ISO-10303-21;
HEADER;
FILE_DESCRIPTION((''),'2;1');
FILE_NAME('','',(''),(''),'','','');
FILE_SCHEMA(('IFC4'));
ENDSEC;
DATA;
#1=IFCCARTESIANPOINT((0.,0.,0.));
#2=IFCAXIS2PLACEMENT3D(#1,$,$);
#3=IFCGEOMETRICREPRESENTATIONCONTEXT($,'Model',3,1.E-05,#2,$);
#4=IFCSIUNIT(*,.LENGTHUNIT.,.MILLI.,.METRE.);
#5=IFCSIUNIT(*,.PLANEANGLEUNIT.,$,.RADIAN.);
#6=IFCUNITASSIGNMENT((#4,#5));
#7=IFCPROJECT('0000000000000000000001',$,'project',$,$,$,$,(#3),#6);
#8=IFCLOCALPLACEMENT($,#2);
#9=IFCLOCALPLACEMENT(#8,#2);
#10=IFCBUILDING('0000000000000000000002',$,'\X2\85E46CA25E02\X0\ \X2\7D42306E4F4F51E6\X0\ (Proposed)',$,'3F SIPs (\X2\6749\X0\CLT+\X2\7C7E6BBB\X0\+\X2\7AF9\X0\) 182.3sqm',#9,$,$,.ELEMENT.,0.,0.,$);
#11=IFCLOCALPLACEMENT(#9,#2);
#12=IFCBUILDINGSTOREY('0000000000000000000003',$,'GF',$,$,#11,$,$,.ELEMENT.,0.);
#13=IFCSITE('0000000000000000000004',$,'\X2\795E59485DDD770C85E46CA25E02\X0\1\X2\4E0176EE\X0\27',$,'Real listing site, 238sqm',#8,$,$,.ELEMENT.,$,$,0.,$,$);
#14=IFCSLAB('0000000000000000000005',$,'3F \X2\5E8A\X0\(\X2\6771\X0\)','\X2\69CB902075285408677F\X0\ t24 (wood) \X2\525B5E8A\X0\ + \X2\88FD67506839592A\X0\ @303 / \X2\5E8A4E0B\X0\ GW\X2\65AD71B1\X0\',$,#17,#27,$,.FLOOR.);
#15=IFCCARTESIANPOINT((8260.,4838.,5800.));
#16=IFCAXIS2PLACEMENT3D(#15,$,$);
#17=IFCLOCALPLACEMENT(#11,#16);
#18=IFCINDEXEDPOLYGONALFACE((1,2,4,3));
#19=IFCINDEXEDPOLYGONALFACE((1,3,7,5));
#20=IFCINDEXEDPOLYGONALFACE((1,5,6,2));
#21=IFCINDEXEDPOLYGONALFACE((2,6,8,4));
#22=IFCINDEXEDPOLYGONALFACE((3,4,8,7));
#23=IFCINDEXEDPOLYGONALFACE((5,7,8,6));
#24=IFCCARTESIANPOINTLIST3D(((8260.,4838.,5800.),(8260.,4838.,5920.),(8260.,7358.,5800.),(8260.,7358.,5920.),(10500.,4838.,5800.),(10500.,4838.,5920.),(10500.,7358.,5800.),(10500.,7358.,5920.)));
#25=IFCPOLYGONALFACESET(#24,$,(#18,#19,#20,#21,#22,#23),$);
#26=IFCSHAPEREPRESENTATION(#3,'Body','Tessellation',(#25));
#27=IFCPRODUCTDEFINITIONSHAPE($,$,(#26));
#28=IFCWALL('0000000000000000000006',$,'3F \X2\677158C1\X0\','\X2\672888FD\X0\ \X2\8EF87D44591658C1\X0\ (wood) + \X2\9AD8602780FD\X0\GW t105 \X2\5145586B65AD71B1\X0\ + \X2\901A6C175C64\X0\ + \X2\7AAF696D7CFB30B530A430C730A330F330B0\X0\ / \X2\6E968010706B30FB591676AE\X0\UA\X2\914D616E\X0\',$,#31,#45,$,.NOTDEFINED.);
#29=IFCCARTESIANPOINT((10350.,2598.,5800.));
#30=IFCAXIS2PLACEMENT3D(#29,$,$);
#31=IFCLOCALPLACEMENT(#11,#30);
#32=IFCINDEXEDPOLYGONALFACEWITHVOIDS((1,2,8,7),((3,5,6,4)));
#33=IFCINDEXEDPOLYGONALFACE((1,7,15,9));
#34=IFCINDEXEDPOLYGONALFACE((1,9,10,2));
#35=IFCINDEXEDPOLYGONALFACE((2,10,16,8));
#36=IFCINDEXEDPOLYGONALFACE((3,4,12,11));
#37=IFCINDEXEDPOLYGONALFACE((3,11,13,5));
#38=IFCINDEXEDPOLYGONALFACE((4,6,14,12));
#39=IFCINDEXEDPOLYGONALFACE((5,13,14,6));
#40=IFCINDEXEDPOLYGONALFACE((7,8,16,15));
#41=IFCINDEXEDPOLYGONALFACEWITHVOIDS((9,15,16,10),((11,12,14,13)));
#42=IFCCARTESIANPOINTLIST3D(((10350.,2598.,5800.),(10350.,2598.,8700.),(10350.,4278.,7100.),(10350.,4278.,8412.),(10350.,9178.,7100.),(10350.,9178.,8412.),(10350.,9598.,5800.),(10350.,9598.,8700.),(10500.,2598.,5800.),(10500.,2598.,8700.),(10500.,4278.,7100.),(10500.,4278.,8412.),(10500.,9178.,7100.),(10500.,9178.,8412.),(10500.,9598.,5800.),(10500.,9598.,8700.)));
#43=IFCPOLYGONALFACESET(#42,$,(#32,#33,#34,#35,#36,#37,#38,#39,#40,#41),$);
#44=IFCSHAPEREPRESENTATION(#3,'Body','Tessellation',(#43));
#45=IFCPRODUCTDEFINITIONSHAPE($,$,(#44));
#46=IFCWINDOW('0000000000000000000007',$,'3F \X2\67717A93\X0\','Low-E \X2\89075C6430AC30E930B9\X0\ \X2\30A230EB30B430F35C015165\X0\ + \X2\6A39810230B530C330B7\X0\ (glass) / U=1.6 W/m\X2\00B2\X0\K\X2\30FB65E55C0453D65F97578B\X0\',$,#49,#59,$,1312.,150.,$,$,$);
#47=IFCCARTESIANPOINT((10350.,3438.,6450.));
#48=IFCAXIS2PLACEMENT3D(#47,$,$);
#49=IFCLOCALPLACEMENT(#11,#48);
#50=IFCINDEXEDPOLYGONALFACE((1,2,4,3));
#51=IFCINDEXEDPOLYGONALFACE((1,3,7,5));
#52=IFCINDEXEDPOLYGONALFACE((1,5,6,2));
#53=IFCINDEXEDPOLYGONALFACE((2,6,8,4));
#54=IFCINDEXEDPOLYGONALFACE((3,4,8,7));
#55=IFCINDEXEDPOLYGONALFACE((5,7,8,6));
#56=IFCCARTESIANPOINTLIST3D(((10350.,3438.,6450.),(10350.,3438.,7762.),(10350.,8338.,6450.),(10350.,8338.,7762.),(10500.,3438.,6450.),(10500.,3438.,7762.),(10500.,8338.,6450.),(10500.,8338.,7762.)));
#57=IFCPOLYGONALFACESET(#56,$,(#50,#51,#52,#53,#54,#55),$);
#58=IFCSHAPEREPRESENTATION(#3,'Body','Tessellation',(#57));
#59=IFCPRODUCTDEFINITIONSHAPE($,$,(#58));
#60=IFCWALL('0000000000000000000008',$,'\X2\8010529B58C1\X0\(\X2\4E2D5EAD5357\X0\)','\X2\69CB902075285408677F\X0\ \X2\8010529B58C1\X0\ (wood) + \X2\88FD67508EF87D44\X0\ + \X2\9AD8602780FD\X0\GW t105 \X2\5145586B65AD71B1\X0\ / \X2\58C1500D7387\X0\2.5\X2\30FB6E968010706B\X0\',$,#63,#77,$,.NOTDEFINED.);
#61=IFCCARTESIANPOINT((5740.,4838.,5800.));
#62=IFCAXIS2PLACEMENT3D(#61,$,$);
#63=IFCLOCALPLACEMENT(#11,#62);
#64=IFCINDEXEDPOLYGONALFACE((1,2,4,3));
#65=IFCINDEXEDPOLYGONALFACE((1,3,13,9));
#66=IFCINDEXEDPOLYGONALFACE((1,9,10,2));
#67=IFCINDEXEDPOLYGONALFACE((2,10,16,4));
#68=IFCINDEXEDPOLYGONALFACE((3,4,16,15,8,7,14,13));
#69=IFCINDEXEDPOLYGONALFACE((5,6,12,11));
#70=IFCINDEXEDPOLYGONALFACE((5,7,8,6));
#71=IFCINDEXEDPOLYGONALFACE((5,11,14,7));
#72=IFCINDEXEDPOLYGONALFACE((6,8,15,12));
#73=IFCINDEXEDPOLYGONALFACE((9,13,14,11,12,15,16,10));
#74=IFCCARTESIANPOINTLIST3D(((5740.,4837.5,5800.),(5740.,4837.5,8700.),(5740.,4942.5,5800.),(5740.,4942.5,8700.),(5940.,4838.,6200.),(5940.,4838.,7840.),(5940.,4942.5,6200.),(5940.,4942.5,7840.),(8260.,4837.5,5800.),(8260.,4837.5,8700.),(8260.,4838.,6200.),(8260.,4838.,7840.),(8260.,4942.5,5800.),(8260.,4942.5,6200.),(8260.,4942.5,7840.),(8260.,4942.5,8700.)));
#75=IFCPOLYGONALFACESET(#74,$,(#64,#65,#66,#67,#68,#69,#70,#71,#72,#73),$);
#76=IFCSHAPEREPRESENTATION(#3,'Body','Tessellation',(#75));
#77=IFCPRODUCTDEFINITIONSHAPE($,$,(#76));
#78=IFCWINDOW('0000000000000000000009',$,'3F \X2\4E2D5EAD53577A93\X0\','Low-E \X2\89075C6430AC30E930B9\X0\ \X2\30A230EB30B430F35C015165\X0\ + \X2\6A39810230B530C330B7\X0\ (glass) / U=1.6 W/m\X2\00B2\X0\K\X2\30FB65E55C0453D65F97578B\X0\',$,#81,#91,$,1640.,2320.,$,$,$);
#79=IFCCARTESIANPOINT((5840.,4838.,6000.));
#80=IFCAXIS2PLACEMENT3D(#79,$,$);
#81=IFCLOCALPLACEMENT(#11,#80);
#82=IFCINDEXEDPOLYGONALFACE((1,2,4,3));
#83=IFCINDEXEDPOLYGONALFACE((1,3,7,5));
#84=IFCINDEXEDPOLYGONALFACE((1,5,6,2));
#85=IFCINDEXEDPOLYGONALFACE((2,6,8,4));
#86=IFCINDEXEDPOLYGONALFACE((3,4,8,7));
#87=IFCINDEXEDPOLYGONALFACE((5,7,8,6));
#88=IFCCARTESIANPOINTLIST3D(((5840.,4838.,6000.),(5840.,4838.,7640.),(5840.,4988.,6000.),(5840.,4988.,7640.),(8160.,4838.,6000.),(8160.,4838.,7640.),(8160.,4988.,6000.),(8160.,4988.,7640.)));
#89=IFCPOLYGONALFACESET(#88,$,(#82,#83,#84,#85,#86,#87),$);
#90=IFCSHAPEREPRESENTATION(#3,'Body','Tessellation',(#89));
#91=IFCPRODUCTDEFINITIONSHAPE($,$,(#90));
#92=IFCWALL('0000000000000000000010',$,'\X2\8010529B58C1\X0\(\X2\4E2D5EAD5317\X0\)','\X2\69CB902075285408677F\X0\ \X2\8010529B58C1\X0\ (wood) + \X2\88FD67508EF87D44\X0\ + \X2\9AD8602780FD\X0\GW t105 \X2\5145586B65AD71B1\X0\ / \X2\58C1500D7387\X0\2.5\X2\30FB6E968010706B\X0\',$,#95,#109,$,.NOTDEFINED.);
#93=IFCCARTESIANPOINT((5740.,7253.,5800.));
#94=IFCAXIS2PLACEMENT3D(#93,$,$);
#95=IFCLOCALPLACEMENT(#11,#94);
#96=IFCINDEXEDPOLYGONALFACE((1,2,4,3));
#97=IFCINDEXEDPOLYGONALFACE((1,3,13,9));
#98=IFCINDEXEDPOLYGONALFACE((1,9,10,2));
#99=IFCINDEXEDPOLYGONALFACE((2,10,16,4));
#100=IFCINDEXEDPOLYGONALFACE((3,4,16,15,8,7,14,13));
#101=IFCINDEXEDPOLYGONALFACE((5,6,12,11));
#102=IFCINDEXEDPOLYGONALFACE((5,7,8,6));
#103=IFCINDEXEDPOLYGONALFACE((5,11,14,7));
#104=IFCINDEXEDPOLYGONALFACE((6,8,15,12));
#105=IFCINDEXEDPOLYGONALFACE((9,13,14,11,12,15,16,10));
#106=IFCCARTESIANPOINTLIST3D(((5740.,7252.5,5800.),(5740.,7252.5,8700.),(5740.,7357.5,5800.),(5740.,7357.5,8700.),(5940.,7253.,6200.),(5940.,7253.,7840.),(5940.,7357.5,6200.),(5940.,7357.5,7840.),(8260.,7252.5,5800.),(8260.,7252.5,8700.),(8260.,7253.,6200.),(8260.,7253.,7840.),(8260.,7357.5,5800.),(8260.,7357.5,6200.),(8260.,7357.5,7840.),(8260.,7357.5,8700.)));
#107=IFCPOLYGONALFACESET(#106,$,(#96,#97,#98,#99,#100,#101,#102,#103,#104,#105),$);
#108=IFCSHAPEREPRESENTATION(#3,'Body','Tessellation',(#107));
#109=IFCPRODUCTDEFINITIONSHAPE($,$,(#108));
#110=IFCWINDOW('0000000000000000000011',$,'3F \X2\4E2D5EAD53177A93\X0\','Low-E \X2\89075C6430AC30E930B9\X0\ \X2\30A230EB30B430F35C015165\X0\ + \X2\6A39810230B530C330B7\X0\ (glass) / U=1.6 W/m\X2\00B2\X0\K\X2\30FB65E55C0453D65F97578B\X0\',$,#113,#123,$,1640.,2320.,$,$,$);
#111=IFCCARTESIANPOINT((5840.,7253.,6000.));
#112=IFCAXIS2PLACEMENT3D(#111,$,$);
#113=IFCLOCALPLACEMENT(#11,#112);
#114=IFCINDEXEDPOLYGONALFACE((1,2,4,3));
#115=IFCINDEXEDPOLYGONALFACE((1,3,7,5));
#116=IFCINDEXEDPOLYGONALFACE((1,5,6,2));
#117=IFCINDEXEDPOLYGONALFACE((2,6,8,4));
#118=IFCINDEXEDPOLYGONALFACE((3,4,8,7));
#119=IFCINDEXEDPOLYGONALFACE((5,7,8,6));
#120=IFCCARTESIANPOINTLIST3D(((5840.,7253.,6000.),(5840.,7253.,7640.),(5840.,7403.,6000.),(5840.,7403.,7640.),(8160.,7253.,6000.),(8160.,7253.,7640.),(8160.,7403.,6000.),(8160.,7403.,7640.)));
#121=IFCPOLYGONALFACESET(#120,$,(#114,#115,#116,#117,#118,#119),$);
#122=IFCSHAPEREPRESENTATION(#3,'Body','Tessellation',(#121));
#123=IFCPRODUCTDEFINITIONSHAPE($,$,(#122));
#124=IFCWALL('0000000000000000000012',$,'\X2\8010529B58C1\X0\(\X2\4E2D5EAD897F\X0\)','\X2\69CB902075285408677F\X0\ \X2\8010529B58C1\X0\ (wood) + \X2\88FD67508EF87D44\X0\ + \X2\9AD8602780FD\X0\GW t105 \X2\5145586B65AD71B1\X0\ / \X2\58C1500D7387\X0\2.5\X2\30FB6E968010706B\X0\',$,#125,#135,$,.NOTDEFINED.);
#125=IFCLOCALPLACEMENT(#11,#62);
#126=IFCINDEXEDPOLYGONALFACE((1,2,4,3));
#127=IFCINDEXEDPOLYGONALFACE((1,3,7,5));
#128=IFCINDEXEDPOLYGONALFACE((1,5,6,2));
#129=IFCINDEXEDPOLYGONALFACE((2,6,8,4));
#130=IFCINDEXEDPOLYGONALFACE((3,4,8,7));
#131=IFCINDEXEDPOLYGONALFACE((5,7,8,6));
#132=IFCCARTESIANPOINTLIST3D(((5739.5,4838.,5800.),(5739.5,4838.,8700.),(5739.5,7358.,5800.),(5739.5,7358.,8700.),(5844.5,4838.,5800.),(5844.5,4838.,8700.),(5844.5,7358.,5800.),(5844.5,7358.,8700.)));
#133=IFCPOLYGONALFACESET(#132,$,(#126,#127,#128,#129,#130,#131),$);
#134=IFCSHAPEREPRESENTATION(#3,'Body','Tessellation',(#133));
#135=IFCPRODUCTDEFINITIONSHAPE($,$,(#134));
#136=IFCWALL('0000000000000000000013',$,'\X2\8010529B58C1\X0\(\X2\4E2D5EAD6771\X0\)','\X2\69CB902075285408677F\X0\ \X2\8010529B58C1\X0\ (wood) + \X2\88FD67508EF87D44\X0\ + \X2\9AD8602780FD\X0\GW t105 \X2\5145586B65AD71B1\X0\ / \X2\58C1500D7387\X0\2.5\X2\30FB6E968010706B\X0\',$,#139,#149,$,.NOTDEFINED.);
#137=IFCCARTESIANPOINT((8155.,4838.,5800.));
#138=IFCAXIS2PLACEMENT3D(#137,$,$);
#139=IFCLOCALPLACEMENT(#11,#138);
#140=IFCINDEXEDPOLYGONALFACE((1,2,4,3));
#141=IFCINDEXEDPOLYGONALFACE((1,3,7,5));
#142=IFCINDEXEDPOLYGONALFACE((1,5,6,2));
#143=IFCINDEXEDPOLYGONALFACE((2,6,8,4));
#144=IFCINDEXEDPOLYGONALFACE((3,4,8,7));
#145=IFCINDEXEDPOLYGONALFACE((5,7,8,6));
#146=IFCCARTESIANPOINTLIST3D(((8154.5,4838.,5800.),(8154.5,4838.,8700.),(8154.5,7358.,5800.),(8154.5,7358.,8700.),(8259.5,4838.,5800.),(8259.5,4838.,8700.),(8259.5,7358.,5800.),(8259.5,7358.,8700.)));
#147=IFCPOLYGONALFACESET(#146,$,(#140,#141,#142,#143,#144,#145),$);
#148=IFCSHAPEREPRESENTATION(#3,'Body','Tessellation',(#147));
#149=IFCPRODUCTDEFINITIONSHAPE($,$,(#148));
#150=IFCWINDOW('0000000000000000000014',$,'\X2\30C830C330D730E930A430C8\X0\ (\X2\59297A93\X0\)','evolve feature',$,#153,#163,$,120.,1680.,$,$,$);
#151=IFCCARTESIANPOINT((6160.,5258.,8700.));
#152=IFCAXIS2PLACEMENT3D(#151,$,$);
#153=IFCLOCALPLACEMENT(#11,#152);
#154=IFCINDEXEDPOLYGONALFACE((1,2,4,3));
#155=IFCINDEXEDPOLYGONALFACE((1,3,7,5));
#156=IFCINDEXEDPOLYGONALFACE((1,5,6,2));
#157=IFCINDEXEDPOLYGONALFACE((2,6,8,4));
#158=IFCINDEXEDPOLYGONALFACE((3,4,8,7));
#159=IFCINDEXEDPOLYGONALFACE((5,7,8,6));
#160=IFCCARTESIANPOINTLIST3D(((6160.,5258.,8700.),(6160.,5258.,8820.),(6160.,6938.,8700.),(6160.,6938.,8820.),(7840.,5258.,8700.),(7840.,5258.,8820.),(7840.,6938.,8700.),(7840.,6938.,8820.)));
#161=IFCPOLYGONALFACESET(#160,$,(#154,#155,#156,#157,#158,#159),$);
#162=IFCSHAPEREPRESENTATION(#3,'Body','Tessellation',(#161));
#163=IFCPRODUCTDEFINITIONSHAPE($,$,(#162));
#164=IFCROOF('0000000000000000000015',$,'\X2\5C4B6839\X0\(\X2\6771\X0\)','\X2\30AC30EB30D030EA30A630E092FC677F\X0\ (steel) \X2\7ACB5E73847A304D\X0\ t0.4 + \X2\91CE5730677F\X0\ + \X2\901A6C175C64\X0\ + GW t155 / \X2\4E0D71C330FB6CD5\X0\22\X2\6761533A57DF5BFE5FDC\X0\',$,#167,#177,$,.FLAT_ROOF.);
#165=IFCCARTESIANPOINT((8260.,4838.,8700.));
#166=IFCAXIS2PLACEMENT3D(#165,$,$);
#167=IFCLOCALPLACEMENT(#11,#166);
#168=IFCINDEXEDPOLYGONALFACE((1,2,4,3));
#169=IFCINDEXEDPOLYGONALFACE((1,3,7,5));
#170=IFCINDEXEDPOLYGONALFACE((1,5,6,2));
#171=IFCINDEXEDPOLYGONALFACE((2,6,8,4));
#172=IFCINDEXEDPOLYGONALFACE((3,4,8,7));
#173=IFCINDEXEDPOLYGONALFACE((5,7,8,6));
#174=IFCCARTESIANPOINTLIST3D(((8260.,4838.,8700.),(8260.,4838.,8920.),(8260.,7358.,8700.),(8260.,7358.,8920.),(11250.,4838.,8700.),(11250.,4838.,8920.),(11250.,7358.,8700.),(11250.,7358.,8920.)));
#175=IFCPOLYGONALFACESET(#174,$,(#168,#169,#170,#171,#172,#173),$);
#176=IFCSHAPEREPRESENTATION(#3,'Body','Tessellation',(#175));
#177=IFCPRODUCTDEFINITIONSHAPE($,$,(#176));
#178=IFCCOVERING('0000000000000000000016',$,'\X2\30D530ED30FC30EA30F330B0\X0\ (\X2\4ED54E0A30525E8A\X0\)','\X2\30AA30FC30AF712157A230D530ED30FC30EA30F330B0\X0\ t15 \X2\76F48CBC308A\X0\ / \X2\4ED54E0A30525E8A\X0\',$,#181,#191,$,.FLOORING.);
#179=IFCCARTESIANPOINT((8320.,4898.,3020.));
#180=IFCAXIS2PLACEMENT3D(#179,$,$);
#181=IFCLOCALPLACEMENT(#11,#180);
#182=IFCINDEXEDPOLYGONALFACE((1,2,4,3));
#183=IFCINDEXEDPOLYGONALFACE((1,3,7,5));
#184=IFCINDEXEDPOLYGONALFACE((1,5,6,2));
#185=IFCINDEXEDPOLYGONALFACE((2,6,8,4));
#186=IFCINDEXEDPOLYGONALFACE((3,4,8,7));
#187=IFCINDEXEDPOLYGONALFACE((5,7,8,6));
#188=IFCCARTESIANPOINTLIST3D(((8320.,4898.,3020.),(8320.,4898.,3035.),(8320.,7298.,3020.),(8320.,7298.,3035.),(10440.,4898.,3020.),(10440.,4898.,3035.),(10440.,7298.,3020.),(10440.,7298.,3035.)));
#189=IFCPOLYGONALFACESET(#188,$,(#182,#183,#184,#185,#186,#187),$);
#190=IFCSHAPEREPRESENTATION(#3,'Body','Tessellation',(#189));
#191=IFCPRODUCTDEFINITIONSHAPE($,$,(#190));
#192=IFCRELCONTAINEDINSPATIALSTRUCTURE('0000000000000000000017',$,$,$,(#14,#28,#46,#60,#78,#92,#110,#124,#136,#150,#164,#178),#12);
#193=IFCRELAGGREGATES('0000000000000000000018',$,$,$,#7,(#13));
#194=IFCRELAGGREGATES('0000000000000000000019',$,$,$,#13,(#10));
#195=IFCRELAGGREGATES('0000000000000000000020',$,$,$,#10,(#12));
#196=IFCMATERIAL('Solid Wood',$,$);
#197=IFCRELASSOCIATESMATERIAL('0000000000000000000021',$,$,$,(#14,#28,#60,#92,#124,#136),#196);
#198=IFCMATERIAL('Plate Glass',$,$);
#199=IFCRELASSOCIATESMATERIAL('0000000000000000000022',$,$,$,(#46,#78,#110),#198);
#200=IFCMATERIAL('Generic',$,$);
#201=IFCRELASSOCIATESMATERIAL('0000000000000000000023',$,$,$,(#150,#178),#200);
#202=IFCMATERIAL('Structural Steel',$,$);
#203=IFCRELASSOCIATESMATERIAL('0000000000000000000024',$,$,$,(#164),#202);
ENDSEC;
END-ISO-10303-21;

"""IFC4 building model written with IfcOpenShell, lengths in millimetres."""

from ifc_helpers import new_model, si_unit, frame, frame_2d, origin, place, context, project, spatial, rectangle, extrude, material, element, fill, save


model = new_model("IFC4")

# Units and contexts
model_context = context("Model", 3, precision=1e-05, world=origin())
ifc_project = project(units=[si_unit("LENGTHUNIT", "METRE", prefix="MILLI"), si_unit("PLANEANGLEUNIT", "RADIAN")], contexts=[model_context])

# Site, building, storey
site_placement = place(None, origin())
site = spatial("IfcSite", under=ifc_project, at=site_placement, Name="神奈川県藤沢市1丁目27", ObjectType="Real listing site, 238sqm", CompositionType="ELEMENT", RefElevation=0.0)
building_placement = place(site_placement, origin())
building = spatial("IfcBuilding", under=site, at=building_placement, Name="藤沢市 終の住処 (Proposed)", ObjectType="3F SIPs (杉CLT+籾殻+竹) 182.3sqm", CompositionType="ELEMENT", ElevationOfRefHeight=0.0, ElevationOfTerrain=0.0)
storey_placement = place(building_placement, origin())
storey = spatial("IfcBuildingStorey", under=building, at=storey_placement, Name="GF", CompositionType="ELEMENT", Elevation=0.0)

# Slab
ifc_material_1 = material(Name="Solid Wood")
slab_placement = place(storey_placement, frame((8260.0, 4838.0, 5800.0)))
element("IfcSlab", 1, at=slab_placement, inside=storey, material=ifc_material_1, Name="3F 床(東)", Description="構造用合板 t24 (wood) 剛床 + 製材根太 @303 / 床下 GW断熱", PredefinedType="FLOOR", context=model_context, shape_type="SweptSolid", body=[
    extrude(rectangle(XDim=2240.0, YDim=2520.0, at=frame_2d((1120.0, 1260.0))), frame((8260.0, 4838.0, 5800.0)), (0.0, 0.0, 1.0), 120.0),
])

# Walls, openings, windows
wall_1_placement = place(storey_placement, frame((10350.0, 2598.0, 5800.0)))
wall_1 = element("IfcWall", 2, at=wall_1_placement, inside=storey, material=ifc_material_1, Name="3F 東壁", Description="木製 軸組外壁 (wood) + 高性能GW t105 充填断熱 + 通気層 + 窯業系サイディング / 準耐火・外皮UA配慮", PredefinedType="NOTDEFINED", context=model_context, shape_type="SweptSolid", body=[
    extrude(rectangle(XDim=150.0, YDim=7000.0, at=frame_2d((75.0, 3500.0))), frame((10350.0, 2598.0, 5800.0)), (0.0, 0.0, 1.0), 2900.0),
])
opening_1_placement = place(storey_placement, frame((10350.0, 3438.0, 6450.0)))
opening_1 = element("IfcOpeningElement", 3, at=opening_1_placement, cuts=wall_1, PredefinedType="NOTDEFINED", context=model_context, shape_type="SweptSolid", body=[
    extrude(rectangle(XDim=150.0, YDim=4900.0, at=frame_2d((75.0, 2450.0))), frame((10350.0, 3438.0, 6450.0)), (0.0, 0.0, 1.0), 1312.0),
])
ifc_material_2 = material(Name="Plate Glass")
window_1_placement = place(storey_placement, frame((10350.0, 3438.0, 6450.0)))
window_1 = element("IfcWindow", 4, at=window_1_placement, inside=storey, material=ifc_material_2, Name="3F 東窓", Description="Low-E 複層ガラス アルゴン封入 + 樹脂サッシ (glass) / U=1.6 W/m²K・日射取得型", OverallHeight=1312.0, OverallWidth=150.0, context=model_context, shape_type="SweptSolid", body=[
    extrude(rectangle(XDim=150.0, YDim=4900.0, at=frame_2d((75.0, 2450.0))), frame((10350.0, 3438.0, 6450.0)), (0.0, 0.0, 1.0), 1312.0),
])
fill(opening_1, window_1)
wall_2_placement = place(storey_placement, frame((5740.0, 4838.0, 5800.0)))
wall_2 = element("IfcWall", 5, at=wall_2_placement, inside=storey, material=ifc_material_1, Name="耐力壁(中庭南)", Description="構造用合板 耐力壁 (wood) + 製材軸組 + 高性能GW t105 充填断熱 / 壁倍率2.5・準耐火", PredefinedType="NOTDEFINED", context=model_context, shape_type="SweptSolid", body=[
    extrude(rectangle(XDim=2520.0, YDim=105.0, at=frame_2d((1260.0, 52.0))), frame((5740.0, 4838.0, 5800.0)), (0.0, 0.0, 1.0), 2900.0),
])
opening_2_placement = place(storey_placement, frame((5840.0, 4838.0, 6000.0)))
opening_2 = element("IfcOpeningElement", 6, at=opening_2_placement, cuts=wall_2, PredefinedType="NOTDEFINED", context=model_context, shape_type="SweptSolid", body=[
    extrude(rectangle(XDim=2320.0, YDim=150.0, at=frame_2d((1160.0, 75.0))), frame((5840.0, 4838.0, 6000.0)), (0.0, 0.0, 1.0), 1640.0),
])
window_2_placement = place(storey_placement, frame((5840.0, 4838.0, 6000.0)))
window_2 = element("IfcWindow", 7, at=window_2_placement, inside=storey, material=ifc_material_2, Name="3F 中庭南窓", Description="Low-E 複層ガラス アルゴン封入 + 樹脂サッシ (glass) / U=1.6 W/m²K・日射取得型", OverallHeight=1640.0, OverallWidth=2320.0, context=model_context, shape_type="SweptSolid", body=[
    extrude(rectangle(XDim=2320.0, YDim=150.0, at=frame_2d((1160.0, 75.0))), frame((5840.0, 4838.0, 6000.0)), (0.0, 0.0, 1.0), 1640.0),
])
fill(opening_2, window_2)
wall_3_placement = place(storey_placement, frame((5740.0, 7253.0, 5800.0)))
wall_3 = element("IfcWall", 8, at=wall_3_placement, inside=storey, material=ifc_material_1, Name="耐力壁(中庭北)", Description="構造用合板 耐力壁 (wood) + 製材軸組 + 高性能GW t105 充填断熱 / 壁倍率2.5・準耐火", PredefinedType="NOTDEFINED", context=model_context, shape_type="SweptSolid", body=[
    extrude(rectangle(XDim=2520.0, YDim=105.0, at=frame_2d((1260.0, 52.0))), frame((5740.0, 7253.0, 5800.0)), (0.0, 0.0, 1.0), 2900.0),
])
opening_3_placement = place(storey_placement, frame((5840.0, 7253.0, 6000.0)))
opening_3 = element("IfcOpeningElement", 9, at=opening_3_placement, cuts=wall_3, PredefinedType="NOTDEFINED", context=model_context, shape_type="SweptSolid", body=[
    extrude(rectangle(XDim=2320.0, YDim=150.0, at=frame_2d((1160.0, 75.0))), frame((5840.0, 7253.0, 6000.0)), (0.0, 0.0, 1.0), 1640.0),
])
window_3_placement = place(storey_placement, frame((5840.0, 7253.0, 6000.0)))
window_3 = element("IfcWindow", 10, at=window_3_placement, inside=storey, material=ifc_material_2, Name="3F 中庭北窓", Description="Low-E 複層ガラス アルゴン封入 + 樹脂サッシ (glass) / U=1.6 W/m²K・日射取得型", OverallHeight=1640.0, OverallWidth=2320.0, context=model_context, shape_type="SweptSolid", body=[
    extrude(rectangle(XDim=2320.0, YDim=150.0, at=frame_2d((1160.0, 75.0))), frame((5840.0, 7253.0, 6000.0)), (0.0, 0.0, 1.0), 1640.0),
])
fill(opening_3, window_3)

# Walls
wall_4_placement = place(storey_placement, frame((5740.0, 4838.0, 5800.0)))
element("IfcWall", 11, at=wall_4_placement, inside=storey, material=ifc_material_1, Name="耐力壁(中庭西)", Description="構造用合板 耐力壁 (wood) + 製材軸組 + 高性能GW t105 充填断熱 / 壁倍率2.5・準耐火", PredefinedType="NOTDEFINED", context=model_context, shape_type="SweptSolid", body=[
    extrude(rectangle(XDim=105.0, YDim=2520.0, at=frame_2d((52.0, 1260.0))), frame((5740.0, 4838.0, 5800.0)), (0.0, 0.0, 1.0), 2900.0),
])
wall_5_placement = place(storey_placement, frame((8155.0, 4838.0, 5800.0)))
element("IfcWall", 12, at=wall_5_placement, inside=storey, material=ifc_material_1, Name="耐力壁(中庭東)", Description="構造用合板 耐力壁 (wood) + 製材軸組 + 高性能GW t105 充填断熱 / 壁倍率2.5・準耐火", PredefinedType="NOTDEFINED", context=model_context, shape_type="SweptSolid", body=[
    extrude(rectangle(XDim=105.0, YDim=2520.0, at=frame_2d((52.0, 1260.0))), frame((8155.0, 4838.0, 5800.0)), (0.0, 0.0, 1.0), 2900.0),
])

# Window
ifc_material_3 = material(Name="Generic")
window_4_placement = place(storey_placement, frame((6160.0, 5258.0, 8700.0)))
element("IfcWindow", 13, at=window_4_placement, inside=storey, material=ifc_material_3, Name="トップライト (天窓)", Description="evolve feature", OverallHeight=120.0, OverallWidth=1680.0, context=model_context, shape_type="SweptSolid", body=[
    extrude(rectangle(XDim=1680.0, YDim=1680.0, at=frame_2d((840.0, 840.0))), frame((6160.0, 5258.0, 8700.0)), (0.0, 0.0, 1.0), 120.0),
])

# Roof
ifc_material_4 = material(Name="Structural Steel")
for number, where, name in (
    (14, (8260.0, 4838.0, 8700.0), "屋根(東)"),
):
    element("IfcRoof", number, at=place(storey_placement, frame(where)), inside=storey, material=ifc_material_4, Name=name, Description="ガルバリウム鋼板 (steel) 立平葺き t0.4 + 野地板 + 通気層 + GW t155 / 不燃・法22条区域対応", PredefinedType="FLAT_ROOF", context=model_context, shape_type="SweptSolid", body=[
        extrude(rectangle(XDim=2990.0, YDim=2520.0, at=frame_2d((1495.0, 1260.0))), frame((8260.0, 4838.0, 8700.0)), (0.0, 0.0, 1.0), 220.0),
    ])

# Covering
covering_1_placement = place(storey_placement, frame((8320.0, 4898.0, 3020.0)))
element("IfcCovering", 15, at=covering_1_placement, inside=storey, material=ifc_material_3, Name="フローリング (仕上げ床)", Description="オーク無垢フローリング t15 直貼り / 仕上げ床", PredefinedType="FLOORING", context=model_context, shape_type="SweptSolid", body=[
    extrude(rectangle(XDim=2120.0, YDim=2400.0, at=frame_2d((1060.0, 1200.0))), frame((8320.0, 4898.0, 3020.0)), (0.0, 0.0, 1.0), 15.0),
])

save(model, "model.ifc")
